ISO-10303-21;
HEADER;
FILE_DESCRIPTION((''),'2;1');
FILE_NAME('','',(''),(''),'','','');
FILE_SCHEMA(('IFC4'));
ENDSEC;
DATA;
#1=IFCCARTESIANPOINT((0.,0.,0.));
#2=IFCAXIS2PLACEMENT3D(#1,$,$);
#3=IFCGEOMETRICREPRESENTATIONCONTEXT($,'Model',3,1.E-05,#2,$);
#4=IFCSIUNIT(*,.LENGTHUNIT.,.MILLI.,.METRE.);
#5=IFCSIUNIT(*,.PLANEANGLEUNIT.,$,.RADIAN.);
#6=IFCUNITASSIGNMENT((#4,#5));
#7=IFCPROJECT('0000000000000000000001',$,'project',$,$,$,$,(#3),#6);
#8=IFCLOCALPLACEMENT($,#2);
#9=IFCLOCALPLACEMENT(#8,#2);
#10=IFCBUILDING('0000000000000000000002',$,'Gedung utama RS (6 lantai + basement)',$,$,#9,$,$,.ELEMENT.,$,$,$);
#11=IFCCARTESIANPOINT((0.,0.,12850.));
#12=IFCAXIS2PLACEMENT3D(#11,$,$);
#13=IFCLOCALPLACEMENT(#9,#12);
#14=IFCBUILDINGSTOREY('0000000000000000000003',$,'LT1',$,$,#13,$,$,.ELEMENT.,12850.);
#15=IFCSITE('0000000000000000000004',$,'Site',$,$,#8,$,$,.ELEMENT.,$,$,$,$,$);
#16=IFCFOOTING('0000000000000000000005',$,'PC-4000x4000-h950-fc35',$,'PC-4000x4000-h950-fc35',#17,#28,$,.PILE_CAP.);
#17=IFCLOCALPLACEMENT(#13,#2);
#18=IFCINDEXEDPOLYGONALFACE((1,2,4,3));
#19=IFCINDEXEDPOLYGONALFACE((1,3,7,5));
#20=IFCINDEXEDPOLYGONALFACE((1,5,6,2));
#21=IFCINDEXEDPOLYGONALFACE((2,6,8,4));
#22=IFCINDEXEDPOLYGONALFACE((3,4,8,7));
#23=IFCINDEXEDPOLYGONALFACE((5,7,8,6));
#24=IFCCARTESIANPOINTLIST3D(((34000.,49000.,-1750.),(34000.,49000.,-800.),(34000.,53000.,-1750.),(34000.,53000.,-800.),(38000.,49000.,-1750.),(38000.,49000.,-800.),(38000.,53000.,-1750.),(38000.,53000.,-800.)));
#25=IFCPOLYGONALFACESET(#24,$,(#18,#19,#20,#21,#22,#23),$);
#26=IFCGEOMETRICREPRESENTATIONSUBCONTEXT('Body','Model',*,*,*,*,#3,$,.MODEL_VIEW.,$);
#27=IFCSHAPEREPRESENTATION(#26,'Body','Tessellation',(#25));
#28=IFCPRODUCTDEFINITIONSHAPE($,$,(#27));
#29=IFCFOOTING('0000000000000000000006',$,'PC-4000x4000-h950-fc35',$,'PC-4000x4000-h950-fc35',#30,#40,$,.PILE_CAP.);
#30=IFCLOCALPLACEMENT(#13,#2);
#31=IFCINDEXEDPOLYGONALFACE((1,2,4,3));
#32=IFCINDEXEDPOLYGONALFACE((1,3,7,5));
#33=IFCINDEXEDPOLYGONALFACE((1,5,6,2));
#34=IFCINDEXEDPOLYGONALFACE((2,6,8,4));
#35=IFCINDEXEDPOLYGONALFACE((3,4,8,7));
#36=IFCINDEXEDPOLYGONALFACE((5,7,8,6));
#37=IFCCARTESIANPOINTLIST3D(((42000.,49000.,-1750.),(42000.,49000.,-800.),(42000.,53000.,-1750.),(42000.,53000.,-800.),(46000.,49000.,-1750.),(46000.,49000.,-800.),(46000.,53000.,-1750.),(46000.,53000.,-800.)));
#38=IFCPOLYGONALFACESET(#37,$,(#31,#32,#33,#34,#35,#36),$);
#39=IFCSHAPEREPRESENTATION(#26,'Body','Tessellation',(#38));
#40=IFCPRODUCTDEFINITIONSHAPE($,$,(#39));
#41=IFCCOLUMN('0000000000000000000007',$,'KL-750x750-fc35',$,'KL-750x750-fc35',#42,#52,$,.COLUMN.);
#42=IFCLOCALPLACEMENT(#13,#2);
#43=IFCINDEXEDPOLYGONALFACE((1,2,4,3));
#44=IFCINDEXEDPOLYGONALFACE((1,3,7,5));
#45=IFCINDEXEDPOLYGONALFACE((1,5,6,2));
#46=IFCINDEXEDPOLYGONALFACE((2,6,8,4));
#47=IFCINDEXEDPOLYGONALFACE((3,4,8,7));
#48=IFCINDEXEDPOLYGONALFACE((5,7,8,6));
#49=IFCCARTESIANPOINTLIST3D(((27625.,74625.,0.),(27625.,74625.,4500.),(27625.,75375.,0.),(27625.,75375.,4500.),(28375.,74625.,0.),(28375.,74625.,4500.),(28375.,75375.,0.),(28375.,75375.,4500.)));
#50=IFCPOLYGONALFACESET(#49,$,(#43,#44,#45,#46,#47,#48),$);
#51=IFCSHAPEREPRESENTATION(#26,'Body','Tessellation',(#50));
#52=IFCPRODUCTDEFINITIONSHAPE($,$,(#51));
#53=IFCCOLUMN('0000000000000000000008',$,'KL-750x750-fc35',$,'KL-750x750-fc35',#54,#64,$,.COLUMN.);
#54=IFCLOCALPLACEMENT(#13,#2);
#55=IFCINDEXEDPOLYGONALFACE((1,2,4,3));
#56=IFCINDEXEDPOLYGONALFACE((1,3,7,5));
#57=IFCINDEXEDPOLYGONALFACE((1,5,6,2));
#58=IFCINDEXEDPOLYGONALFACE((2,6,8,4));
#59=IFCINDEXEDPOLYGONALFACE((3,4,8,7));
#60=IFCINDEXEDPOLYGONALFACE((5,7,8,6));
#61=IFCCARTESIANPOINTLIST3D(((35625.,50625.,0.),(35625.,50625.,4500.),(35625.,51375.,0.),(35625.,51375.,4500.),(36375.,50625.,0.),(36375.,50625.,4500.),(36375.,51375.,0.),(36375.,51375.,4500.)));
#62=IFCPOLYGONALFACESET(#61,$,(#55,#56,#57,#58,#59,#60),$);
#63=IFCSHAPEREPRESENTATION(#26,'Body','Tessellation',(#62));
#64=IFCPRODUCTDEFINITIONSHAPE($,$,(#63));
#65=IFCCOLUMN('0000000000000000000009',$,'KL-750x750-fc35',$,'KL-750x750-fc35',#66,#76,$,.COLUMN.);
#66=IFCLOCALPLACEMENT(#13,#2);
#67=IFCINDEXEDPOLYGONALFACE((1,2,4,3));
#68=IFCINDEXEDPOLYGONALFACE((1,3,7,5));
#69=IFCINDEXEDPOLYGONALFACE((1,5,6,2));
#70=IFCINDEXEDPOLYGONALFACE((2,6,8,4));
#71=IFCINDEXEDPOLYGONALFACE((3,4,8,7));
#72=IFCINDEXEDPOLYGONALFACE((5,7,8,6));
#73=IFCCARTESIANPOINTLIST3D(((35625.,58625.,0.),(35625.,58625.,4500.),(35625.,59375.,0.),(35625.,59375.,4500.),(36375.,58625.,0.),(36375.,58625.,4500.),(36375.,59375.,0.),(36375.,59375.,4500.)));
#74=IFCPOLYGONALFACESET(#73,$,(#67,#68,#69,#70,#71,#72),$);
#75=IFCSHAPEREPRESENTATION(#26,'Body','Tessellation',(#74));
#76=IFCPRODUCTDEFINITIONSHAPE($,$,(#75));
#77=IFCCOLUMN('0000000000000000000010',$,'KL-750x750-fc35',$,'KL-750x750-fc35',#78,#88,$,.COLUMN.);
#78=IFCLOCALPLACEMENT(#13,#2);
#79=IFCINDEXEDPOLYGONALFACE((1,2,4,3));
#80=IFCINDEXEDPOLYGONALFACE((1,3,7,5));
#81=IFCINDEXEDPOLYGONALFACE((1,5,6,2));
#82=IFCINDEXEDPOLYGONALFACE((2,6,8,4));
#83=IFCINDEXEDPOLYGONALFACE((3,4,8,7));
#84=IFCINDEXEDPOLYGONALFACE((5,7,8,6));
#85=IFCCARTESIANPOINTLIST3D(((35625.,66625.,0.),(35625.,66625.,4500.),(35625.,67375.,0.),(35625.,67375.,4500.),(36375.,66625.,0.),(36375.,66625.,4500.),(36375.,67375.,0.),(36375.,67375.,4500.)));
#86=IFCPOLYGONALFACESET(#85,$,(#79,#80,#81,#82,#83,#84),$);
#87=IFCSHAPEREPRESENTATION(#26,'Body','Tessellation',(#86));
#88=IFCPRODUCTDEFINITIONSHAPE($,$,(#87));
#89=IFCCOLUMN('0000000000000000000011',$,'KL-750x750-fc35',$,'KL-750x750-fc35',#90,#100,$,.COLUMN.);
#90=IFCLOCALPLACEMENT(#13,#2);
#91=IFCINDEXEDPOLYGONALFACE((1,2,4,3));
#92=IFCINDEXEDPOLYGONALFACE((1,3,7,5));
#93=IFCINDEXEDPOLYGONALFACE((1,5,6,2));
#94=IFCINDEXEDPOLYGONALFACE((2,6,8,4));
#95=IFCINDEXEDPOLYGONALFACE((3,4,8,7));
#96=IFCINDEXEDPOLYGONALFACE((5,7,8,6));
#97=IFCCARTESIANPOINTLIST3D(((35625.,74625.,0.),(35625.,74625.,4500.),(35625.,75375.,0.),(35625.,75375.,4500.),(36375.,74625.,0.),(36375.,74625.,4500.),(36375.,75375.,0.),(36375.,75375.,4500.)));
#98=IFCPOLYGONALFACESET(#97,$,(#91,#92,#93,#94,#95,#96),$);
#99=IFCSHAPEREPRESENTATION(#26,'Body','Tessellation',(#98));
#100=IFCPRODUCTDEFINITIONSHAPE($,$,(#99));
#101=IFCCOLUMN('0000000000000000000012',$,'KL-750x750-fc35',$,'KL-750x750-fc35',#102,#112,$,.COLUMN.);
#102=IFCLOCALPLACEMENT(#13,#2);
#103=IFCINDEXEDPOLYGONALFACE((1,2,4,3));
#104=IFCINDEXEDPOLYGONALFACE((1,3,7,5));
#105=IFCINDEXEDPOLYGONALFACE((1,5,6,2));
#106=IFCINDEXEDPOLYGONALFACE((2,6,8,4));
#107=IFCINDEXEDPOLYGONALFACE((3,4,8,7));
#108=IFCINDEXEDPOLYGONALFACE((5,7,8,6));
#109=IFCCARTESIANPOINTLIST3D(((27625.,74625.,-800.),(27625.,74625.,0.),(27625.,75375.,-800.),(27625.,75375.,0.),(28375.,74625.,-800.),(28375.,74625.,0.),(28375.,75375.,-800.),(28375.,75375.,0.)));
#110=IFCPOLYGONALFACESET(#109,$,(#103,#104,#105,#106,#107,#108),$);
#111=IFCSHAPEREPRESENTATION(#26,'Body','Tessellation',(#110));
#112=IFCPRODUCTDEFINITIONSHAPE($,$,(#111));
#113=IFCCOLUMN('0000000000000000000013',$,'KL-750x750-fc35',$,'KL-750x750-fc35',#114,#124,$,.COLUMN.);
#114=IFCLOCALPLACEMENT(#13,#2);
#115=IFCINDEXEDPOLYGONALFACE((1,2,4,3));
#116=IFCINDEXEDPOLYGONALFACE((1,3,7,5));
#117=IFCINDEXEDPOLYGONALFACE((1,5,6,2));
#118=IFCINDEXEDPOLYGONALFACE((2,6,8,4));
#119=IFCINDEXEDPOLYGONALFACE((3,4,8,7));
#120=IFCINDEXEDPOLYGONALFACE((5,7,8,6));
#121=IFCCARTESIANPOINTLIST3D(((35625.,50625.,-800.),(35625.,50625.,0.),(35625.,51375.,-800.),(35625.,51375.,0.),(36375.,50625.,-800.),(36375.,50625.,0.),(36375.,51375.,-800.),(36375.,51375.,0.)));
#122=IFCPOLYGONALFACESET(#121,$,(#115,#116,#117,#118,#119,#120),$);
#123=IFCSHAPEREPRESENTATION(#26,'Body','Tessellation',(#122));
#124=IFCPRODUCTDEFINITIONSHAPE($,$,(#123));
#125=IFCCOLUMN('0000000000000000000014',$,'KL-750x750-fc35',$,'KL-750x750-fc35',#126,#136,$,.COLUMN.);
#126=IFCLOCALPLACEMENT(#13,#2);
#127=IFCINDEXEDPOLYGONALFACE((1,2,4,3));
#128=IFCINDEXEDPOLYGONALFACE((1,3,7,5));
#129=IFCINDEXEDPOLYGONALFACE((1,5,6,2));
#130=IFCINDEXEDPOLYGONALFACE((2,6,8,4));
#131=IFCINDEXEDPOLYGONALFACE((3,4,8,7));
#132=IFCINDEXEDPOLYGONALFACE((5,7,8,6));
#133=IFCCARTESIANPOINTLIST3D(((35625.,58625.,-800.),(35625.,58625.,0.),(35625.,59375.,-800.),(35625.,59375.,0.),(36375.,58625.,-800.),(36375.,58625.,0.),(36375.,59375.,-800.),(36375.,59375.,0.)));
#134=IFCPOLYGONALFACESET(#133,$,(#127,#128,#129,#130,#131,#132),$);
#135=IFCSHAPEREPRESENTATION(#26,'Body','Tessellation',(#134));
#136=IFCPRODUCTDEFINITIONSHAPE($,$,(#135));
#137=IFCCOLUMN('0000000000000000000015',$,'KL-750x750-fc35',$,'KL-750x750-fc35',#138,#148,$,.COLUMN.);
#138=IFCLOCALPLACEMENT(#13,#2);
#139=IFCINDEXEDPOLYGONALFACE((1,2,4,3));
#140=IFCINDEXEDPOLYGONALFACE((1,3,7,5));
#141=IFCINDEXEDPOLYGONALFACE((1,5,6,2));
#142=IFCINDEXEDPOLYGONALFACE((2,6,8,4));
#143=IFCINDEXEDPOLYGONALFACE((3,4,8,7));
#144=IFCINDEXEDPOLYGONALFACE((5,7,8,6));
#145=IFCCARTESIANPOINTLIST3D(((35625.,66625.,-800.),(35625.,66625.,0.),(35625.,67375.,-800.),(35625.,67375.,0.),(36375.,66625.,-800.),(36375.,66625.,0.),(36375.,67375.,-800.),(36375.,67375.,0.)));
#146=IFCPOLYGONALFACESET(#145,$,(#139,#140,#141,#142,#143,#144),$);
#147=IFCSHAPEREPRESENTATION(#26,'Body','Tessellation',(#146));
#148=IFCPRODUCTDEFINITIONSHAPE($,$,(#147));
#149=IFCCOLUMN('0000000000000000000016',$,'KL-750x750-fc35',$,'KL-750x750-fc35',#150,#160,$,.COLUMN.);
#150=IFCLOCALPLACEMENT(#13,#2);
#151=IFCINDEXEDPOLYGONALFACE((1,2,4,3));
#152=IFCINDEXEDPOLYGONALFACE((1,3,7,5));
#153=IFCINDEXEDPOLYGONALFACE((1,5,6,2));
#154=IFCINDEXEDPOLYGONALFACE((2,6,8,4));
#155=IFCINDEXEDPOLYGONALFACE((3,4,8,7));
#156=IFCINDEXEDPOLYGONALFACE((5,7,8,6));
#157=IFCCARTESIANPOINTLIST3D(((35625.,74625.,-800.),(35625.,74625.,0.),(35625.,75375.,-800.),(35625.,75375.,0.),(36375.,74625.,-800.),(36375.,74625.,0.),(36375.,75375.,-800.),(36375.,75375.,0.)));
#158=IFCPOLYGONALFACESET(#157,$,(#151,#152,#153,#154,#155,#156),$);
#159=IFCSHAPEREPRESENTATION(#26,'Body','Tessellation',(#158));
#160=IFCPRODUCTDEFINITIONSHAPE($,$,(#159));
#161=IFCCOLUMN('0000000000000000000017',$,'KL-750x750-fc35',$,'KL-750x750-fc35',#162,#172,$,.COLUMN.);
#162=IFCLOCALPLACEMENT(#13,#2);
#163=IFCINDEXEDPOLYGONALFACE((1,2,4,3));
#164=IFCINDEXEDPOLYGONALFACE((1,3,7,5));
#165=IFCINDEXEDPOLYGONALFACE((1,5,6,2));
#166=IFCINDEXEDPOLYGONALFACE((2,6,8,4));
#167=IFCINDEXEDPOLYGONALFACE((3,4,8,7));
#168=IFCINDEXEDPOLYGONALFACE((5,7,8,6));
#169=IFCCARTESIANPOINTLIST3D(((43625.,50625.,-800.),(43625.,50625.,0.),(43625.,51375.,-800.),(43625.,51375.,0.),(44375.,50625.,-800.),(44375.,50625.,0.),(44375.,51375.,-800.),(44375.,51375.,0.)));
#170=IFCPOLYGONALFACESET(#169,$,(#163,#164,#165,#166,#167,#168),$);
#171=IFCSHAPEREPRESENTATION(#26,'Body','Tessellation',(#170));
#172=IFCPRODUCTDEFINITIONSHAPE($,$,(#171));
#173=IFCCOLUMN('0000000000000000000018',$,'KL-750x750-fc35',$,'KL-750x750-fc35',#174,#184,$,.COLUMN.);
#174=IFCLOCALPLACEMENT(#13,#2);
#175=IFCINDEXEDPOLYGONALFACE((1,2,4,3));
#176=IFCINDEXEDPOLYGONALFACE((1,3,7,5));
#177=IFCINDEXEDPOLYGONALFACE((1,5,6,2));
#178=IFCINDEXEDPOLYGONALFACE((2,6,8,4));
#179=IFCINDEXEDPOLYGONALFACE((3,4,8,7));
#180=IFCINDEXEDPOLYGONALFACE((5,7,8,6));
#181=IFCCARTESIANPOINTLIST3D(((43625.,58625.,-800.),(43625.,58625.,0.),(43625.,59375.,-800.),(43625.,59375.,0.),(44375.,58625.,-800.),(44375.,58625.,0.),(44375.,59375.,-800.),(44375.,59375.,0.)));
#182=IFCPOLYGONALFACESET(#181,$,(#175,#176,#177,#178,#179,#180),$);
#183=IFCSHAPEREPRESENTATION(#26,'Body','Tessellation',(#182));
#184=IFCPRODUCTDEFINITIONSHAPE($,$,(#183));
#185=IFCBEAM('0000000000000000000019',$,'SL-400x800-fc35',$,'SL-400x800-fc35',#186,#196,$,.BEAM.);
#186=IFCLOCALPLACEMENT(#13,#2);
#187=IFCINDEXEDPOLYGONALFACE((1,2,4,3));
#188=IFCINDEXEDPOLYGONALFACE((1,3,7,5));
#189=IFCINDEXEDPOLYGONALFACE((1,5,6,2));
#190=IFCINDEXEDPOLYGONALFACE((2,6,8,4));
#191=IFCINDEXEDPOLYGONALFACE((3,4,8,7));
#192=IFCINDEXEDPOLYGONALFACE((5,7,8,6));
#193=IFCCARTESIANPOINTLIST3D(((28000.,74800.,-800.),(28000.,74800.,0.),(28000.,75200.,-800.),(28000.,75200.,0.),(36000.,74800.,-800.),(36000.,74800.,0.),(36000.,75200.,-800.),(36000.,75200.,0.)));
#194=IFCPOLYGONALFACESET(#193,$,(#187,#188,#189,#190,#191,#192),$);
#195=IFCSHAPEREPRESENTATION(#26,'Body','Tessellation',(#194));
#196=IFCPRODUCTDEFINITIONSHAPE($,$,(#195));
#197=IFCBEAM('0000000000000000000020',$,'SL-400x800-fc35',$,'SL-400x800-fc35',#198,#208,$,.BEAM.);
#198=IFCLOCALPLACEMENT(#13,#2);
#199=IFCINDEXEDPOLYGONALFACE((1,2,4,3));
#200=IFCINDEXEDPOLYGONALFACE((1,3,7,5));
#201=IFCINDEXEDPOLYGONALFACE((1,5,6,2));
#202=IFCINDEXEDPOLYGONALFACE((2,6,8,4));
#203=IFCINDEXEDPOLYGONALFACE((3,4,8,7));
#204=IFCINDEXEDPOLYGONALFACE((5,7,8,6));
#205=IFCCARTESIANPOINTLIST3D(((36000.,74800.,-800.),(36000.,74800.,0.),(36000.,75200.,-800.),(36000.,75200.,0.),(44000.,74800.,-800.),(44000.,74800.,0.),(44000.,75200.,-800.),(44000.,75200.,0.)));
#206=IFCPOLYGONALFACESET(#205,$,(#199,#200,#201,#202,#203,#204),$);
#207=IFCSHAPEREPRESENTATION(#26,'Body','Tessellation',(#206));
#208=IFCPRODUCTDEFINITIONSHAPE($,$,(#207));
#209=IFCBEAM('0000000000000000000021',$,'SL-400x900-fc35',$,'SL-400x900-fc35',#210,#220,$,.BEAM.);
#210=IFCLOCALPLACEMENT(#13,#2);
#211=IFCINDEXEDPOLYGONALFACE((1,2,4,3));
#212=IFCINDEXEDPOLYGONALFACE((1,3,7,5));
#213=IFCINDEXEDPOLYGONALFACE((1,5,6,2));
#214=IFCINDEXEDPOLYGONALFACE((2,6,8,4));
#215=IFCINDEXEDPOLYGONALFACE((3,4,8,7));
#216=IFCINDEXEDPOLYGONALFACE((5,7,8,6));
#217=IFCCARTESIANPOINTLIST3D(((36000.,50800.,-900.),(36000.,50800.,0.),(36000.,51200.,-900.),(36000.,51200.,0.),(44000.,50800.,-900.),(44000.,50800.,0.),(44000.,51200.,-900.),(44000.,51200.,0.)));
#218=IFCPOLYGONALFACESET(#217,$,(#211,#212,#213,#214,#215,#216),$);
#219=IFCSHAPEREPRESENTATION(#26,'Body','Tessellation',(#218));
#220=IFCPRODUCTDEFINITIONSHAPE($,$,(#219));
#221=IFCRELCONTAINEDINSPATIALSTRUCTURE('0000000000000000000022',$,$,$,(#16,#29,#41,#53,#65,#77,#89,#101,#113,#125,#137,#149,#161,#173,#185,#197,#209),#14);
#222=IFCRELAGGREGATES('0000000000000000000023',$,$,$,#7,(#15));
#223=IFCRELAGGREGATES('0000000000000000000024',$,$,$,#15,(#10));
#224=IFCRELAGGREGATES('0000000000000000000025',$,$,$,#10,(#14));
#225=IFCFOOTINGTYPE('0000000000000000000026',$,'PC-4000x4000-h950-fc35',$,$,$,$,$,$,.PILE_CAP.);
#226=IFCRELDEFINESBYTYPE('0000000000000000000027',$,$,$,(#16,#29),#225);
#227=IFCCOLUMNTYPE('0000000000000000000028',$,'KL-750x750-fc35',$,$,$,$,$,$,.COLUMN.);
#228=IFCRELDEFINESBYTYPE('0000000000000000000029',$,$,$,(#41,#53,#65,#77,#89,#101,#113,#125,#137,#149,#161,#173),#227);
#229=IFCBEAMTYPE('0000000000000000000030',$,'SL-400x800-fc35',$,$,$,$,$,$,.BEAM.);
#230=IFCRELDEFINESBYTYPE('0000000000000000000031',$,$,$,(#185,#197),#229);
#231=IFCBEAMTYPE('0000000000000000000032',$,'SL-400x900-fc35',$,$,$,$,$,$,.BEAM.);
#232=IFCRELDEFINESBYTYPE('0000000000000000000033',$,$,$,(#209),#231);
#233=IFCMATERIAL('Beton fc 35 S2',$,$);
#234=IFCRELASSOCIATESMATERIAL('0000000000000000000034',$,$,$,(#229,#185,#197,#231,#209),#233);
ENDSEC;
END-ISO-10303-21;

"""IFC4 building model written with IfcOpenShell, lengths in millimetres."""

from ifc_helpers import new_model, si_unit, frame, origin, origin_2d, place, context, subcontext, project, spatial, rectangle, extrude, material, material_profile, profile_set, profile_usage, type_object, element, save


model = new_model("IFC4")

# Units and contexts
model_context = context("Model", 3, precision=1e-05, world=origin())
body_context = subcontext(model_context, "Body", "Model", "MODEL_VIEW")
ifc_project = project(units=[si_unit("LENGTHUNIT", "METRE", prefix="MILLI"), si_unit("PLANEANGLEUNIT", "RADIAN")], contexts=[model_context])

# Site, building, storey
site_placement = place(None, origin())
site = spatial("IfcSite", under=ifc_project, at=site_placement, Name="Site", CompositionType="ELEMENT")
building_placement = place(site_placement, origin())
building = spatial("IfcBuilding", under=site, at=building_placement, Name="Gedung utama RS (6 lantai + basement)", CompositionType="ELEMENT")
storey_placement = place(building_placement, frame((0.0, 0.0, 12850.0)))
storey = spatial("IfcBuildingStorey", under=building, at=storey_placement, Name="LT1", CompositionType="ELEMENT", Elevation=12850.0)

# Footings
ifc_material_profile_1 = material_profile(None, rectangle(XDim=4000.0, YDim=4000.0, at=origin_2d()), Name="PC-4000x4000-h950-fc35")
ifc_profile_set_1 = profile_set([ifc_material_profile_1], Name="PC-4000x4000-h950-fc35")
ifc_profile_usage_1 = profile_usage(ifc_profile_set_1, cardinal=5)
footing_type = type_object("IfcFootingType", Name="PC-4000x4000-h950-fc35", PredefinedType="PILE_CAP", material=ifc_profile_set_1)
for number, where, z_axis, x_axis, name in (
    (1, (36000.0, 51000.0, -1750.0), (0.0, 0.0, 1.0), (1.0, 0.0, 0.0), "PC-4000x4000-h950-fc35"),
    (2, (44000.0, 51000.0, -1750.0), (0.0, 0.0, 1.0), (1.0, 0.0, 0.0), "PC-4000x4000-h950-fc35"),
):
    element("IfcFooting", number, at=place(storey_placement, frame(where, z_axis=z_axis, x_axis=x_axis)), inside=storey, type_object=footing_type, material=ifc_profile_usage_1, Name=name, ObjectType="PC-4000x4000-h950-fc35", PredefinedType="PILE_CAP", context=body_context, shape_type="SweptSolid", body=[
        extrude(rectangle(XDim=4000.0, YDim=4000.0, at=origin_2d()), origin(), (0.0, 0.0, 1.0), 950.0),
    ])

# Columns
ifc_material_profile_2 = material_profile(None, rectangle(XDim=750.0, YDim=750.0, at=origin_2d()), Name="KL-750x750-fc35")
ifc_profile_set_2 = profile_set([ifc_material_profile_2], Name="KL-750x750-fc35")
ifc_profile_usage_2 = profile_usage(ifc_profile_set_2, cardinal=5)
column_type = type_object("IfcColumnType", Name="KL-750x750-fc35", PredefinedType="COLUMN", material=ifc_profile_set_2)
for number, where, z_axis, x_axis, name in (
    (3, (28000.0, 75000.0, 0.0), (0.0, 0.0, 1.0), (1.0, 0.0, 0.0), "KL-750x750-fc35"),
    (4, (36000.0, 51000.0, 0.0), (0.0, 0.0, 1.0), (1.0, 0.0, 0.0), "KL-750x750-fc35"),
    (5, (36000.0, 59000.0, 0.0), (0.0, 0.0, 1.0), (1.0, 0.0, 0.0), "KL-750x750-fc35"),
    (6, (36000.0, 67000.0, 0.0), (0.0, 0.0, 1.0), (1.0, 0.0, 0.0), "KL-750x750-fc35"),
    (7, (36000.0, 75000.0, 0.0), (0.0, 0.0, 1.0), (1.0, 0.0, 0.0), "KL-750x750-fc35"),
):
    element("IfcColumn", number, at=place(storey_placement, frame(where, z_axis=z_axis, x_axis=x_axis)), inside=storey, type_object=column_type, material=ifc_profile_usage_2, Name=name, ObjectType="KL-750x750-fc35", PredefinedType="COLUMN", context=body_context, shape_type="SweptSolid", body=[
        extrude(rectangle(XDim=750.0, YDim=750.0, at=origin_2d()), origin(), (0.0, 0.0, 1.0), 4500.0),
    ])
for number, where, z_axis, x_axis, name in (
    (8, (28000.0, 75000.0, -800.0), (0.0, 0.0, 1.0), (1.0, 0.0, 0.0), "KL-750x750-fc35"),
    (9, (36000.0, 51000.0, -800.0), (0.0, 0.0, 1.0), (1.0, 0.0, 0.0), "KL-750x750-fc35"),
    (10, (36000.0, 59000.0, -800.0), (0.0, 0.0, 1.0), (1.0, 0.0, 0.0), "KL-750x750-fc35"),
    (11, (36000.0, 67000.0, -800.0), (0.0, 0.0, 1.0), (1.0, 0.0, 0.0), "KL-750x750-fc35"),
    (12, (36000.0, 75000.0, -800.0), (0.0, 0.0, 1.0), (1.0, 0.0, 0.0), "KL-750x750-fc35"),
    (13, (44000.0, 51000.0, -800.0), (0.0, 0.0, 1.0), (1.0, 0.0, 0.0), "KL-750x750-fc35"),
    (14, (44000.0, 59000.0, -800.0), (0.0, 0.0, 1.0), (1.0, 0.0, 0.0), "KL-750x750-fc35"),
):
    element("IfcColumn", number, at=place(storey_placement, frame(where, z_axis=z_axis, x_axis=x_axis)), inside=storey, type_object=column_type, material=ifc_profile_usage_2, Name=name, ObjectType="KL-750x750-fc35", PredefinedType="COLUMN", context=body_context, shape_type="SweptSolid", body=[
        extrude(rectangle(XDim=750.0, YDim=750.0, at=origin_2d()), origin(), (0.0, 0.0, 1.0), 800.0),
    ])

# Beams
ifc_material = material(Name="Beton fc 35 S2")
ifc_material_profile_3 = material_profile(ifc_material, rectangle(XDim=400.0, YDim=800.0, at=origin_2d()), Name="SL-400x800-fc35")
ifc_profile_set_3 = profile_set([ifc_material_profile_3], Name="SL-400x800-fc35")
ifc_profile_usage_3 = profile_usage(ifc_profile_set_3, cardinal=8)
beam_type_1 = type_object("IfcBeamType", Name="SL-400x800-fc35", PredefinedType="BEAM", material=ifc_profile_set_3)
for number, where, name in (
    (15, (28000.0, 75000.0, -400.0), "SL-400x800-fc35"),
    (16, (36000.0, 75000.0, -400.0), "SL-400x800-fc35"),
):
    element("IfcBeam", number, at=place(storey_placement, frame(where)), inside=storey, type_object=beam_type_1, material=ifc_profile_usage_3, Name=name, ObjectType="SL-400x800-fc35", PredefinedType="BEAM", context=body_context, shape_type="SweptSolid", body=[
        extrude(rectangle(XDim=400.0, YDim=800.0, at=origin_2d()), frame((0.0, 0.0, 0.0), z_axis=(1.0, 0.0, 0.0), x_axis=(0.0, 1.0, 0.0)), (0.0, 0.0, 1.0), 8000.0),
    ])
ifc_material_profile_4 = material_profile(ifc_material, rectangle(XDim=400.0, YDim=900.0, at=origin_2d()), Name="SL-400x900-fc35")
ifc_profile_set_4 = profile_set([ifc_material_profile_4], Name="SL-400x900-fc35")
ifc_profile_usage_4 = profile_usage(ifc_profile_set_4, cardinal=8)
beam_type_2 = type_object("IfcBeamType", Name="SL-400x900-fc35", PredefinedType="BEAM", material=ifc_profile_set_4)
beam_1_placement = place(storey_placement, frame((36000.0, 51000.0, -450.0)))
element("IfcBeam", 17, at=beam_1_placement, inside=storey, type_object=beam_type_2, material=ifc_profile_usage_4, Name="SL-400x900-fc35", ObjectType="SL-400x900-fc35", PredefinedType="BEAM", context=body_context, shape_type="SweptSolid", body=[
    extrude(rectangle(XDim=400.0, YDim=900.0, at=origin_2d()), frame((0.0, 0.0, 0.0), z_axis=(1.0, 0.0, 0.0), x_axis=(0.0, 1.0, 0.0)), (0.0, 0.0, 1.0), 8000.0),
])

save(model, "model.ifc")
